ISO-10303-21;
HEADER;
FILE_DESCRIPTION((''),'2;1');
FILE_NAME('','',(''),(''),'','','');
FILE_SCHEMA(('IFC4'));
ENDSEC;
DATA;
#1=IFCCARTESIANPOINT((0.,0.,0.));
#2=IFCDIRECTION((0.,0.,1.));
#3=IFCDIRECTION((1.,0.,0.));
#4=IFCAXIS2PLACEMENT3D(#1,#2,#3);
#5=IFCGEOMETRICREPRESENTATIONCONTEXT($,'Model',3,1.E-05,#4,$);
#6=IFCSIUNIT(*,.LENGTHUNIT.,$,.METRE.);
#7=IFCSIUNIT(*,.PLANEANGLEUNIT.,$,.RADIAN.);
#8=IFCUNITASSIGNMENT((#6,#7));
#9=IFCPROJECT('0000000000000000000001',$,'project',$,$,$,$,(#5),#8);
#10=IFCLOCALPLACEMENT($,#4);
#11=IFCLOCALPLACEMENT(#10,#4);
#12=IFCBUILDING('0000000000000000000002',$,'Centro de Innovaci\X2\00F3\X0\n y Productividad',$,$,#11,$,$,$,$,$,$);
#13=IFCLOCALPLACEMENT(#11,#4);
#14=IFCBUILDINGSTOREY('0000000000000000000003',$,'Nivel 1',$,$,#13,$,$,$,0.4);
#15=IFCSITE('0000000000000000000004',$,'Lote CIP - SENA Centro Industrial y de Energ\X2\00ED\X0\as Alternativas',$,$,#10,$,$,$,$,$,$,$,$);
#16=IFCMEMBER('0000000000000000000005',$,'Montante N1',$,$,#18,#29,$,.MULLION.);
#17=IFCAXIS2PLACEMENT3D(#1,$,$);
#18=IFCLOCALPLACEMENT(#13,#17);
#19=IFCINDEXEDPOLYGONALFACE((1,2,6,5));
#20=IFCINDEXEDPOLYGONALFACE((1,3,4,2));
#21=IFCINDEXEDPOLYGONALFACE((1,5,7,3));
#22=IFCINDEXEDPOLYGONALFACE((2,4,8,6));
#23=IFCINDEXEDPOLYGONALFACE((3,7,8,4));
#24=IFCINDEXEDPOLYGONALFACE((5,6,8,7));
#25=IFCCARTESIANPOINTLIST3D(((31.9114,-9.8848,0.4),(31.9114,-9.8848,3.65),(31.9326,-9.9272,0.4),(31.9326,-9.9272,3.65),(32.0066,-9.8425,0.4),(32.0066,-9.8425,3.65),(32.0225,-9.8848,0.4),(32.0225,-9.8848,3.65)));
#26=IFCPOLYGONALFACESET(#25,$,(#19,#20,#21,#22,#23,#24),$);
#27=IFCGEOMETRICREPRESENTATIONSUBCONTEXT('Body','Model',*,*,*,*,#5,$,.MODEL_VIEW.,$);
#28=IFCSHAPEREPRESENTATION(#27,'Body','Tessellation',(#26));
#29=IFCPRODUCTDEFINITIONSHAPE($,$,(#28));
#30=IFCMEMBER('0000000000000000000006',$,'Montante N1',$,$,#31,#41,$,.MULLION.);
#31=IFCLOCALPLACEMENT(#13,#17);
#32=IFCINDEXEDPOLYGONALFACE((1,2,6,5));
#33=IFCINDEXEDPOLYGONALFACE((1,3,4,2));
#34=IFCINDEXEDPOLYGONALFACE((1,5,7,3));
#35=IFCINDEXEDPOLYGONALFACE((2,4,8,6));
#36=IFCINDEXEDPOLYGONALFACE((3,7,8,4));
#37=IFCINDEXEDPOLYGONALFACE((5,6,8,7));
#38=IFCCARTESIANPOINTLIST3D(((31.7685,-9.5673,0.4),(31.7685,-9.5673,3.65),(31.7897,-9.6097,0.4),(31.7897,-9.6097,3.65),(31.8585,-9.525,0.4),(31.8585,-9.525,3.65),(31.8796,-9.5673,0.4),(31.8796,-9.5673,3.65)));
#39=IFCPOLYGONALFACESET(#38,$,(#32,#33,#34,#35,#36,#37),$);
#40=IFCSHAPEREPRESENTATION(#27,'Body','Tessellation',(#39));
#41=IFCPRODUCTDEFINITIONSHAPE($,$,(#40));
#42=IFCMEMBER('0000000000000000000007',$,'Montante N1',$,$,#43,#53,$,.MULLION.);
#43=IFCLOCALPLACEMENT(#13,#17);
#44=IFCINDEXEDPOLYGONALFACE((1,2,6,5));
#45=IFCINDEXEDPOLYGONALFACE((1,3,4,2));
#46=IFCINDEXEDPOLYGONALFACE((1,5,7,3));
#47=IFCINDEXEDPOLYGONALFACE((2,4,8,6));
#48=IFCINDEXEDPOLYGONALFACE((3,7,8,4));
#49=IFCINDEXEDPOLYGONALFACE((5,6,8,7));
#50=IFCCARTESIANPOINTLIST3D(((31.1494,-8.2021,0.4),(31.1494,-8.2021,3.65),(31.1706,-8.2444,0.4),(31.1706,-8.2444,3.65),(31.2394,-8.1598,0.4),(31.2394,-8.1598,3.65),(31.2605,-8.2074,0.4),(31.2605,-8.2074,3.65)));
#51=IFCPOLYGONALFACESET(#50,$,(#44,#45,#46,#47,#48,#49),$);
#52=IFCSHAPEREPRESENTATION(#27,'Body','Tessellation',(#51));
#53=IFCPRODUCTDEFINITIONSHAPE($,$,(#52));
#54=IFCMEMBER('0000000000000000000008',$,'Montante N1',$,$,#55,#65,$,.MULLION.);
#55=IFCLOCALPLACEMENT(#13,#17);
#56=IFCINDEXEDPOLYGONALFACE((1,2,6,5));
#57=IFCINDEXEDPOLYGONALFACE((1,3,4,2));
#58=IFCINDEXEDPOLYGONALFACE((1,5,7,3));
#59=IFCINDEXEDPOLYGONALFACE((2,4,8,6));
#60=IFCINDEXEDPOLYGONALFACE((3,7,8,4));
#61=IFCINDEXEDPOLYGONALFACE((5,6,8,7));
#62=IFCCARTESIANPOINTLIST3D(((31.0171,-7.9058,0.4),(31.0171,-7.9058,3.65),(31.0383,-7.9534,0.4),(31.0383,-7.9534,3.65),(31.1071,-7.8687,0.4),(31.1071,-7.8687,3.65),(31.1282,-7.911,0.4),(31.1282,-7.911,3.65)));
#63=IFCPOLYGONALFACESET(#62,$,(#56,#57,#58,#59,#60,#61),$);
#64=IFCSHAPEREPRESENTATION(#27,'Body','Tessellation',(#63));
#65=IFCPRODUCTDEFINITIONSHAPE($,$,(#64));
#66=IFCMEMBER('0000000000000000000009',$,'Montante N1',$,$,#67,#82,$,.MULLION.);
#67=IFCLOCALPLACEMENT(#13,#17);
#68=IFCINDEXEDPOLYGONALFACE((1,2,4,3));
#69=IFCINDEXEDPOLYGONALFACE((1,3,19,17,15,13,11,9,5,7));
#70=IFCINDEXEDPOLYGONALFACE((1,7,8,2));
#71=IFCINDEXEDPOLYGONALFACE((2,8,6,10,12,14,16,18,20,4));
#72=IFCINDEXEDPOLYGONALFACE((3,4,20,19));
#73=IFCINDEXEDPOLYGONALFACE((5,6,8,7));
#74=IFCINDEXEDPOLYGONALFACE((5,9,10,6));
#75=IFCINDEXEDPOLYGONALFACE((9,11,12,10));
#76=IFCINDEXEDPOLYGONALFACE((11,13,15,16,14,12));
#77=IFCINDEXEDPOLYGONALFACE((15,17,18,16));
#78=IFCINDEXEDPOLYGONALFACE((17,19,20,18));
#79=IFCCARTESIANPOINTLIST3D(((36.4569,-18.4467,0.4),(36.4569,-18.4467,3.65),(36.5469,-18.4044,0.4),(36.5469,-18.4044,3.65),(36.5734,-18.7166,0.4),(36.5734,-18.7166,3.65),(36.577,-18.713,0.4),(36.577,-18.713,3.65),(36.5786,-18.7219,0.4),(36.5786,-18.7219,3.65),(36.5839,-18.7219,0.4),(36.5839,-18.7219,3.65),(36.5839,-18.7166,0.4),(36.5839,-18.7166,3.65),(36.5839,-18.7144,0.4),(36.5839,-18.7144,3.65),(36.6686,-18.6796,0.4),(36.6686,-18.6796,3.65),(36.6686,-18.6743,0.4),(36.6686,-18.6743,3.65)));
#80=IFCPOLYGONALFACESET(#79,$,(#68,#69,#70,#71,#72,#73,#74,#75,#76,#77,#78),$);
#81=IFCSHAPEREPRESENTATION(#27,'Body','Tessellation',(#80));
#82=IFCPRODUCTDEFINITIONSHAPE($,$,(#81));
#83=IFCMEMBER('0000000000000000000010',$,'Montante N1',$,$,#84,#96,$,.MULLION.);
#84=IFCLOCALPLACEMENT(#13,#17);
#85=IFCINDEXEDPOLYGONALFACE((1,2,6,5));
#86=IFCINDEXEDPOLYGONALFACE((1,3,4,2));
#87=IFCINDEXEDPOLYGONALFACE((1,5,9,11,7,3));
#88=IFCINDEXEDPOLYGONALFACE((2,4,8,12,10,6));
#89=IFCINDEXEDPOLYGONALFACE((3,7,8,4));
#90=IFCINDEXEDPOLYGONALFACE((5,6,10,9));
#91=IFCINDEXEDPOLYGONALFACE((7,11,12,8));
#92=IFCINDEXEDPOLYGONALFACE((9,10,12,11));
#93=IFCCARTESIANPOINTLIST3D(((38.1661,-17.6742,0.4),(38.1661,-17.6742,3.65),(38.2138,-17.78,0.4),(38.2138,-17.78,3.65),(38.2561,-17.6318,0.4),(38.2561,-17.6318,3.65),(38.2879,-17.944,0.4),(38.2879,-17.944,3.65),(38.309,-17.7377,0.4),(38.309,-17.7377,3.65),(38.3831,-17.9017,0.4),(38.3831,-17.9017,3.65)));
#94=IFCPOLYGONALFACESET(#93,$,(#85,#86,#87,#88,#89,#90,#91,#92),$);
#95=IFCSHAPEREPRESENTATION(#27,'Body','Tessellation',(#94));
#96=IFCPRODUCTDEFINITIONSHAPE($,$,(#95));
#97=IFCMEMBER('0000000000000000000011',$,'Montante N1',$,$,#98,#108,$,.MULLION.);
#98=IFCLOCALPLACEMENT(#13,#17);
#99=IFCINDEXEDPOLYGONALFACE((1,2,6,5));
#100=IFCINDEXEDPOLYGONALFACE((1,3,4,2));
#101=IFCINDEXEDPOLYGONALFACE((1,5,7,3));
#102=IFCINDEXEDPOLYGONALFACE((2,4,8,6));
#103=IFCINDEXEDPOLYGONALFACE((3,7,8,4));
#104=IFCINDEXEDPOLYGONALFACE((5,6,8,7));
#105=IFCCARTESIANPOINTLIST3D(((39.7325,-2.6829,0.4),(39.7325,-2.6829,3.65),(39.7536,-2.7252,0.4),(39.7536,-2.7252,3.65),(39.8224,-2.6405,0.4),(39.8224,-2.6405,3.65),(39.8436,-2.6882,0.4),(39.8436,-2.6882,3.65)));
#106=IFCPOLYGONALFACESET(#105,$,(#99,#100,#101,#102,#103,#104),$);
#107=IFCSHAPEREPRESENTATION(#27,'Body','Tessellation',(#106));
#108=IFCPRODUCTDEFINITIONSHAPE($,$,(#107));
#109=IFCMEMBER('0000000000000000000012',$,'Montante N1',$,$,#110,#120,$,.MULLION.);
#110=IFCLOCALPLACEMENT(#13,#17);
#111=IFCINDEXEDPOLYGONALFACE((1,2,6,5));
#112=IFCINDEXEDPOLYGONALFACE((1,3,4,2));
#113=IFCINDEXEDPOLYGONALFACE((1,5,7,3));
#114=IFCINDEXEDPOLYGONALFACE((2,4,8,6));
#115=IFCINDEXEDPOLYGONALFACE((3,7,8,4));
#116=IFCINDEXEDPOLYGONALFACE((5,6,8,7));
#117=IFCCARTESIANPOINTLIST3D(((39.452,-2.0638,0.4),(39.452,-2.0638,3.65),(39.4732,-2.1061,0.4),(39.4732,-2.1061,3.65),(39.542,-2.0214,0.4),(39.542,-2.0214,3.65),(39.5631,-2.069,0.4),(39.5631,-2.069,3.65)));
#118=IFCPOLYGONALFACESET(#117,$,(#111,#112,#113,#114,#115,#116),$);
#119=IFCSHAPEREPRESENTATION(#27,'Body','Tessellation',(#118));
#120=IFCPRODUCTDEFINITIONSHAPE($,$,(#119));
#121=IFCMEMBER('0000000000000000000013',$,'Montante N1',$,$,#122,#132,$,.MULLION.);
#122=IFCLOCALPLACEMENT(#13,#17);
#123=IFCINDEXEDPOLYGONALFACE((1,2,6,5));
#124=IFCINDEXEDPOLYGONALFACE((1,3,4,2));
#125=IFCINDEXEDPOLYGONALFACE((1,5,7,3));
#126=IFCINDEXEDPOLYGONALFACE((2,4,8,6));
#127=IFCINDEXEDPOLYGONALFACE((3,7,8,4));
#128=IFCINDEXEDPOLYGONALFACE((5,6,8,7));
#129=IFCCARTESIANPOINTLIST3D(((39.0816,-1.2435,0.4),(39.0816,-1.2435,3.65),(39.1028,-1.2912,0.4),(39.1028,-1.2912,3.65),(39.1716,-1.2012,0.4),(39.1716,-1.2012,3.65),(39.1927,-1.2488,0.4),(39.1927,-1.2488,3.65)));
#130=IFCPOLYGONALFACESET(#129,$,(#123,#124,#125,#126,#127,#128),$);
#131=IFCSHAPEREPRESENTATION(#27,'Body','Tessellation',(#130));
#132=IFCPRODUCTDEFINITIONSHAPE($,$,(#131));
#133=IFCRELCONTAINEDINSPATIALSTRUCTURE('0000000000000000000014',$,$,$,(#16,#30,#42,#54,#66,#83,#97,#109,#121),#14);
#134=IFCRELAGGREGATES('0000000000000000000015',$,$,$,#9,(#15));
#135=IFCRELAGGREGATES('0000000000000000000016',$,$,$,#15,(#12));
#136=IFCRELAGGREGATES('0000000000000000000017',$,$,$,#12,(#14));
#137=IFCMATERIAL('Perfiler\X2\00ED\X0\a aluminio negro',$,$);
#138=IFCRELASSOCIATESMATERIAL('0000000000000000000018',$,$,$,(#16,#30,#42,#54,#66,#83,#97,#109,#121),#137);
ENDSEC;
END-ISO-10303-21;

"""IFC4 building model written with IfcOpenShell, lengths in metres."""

from ifc_helpers import new_model, si_unit, frame, origin_with_axes, place, context, subcontext, project, spatial, polyline, outline, extrude, material, element, save


model = new_model("IFC4")

# Units and contexts
model_context = context("Model", 3, precision=1e-05, world=origin_with_axes())
body_context = subcontext(model_context, "Body", "Model", "MODEL_VIEW")
ifc_project = project(units=[si_unit("LENGTHUNIT", "METRE"), si_unit("PLANEANGLEUNIT", "RADIAN")], contexts=[model_context])

# Site, building, storey
site_placement = place(None, origin_with_axes())
site = spatial("IfcSite", under=ifc_project, at=site_placement, Name="Lote CIP - SENA Centro Industrial y de Energías Alternativas")
building_placement = place(site_placement, origin_with_axes())
building = spatial("IfcBuilding", under=site, at=building_placement, Name="Centro de Innovación y Productividad")
storey_placement = place(building_placement, origin_with_axes())
storey = spatial("IfcBuildingStorey", under=building, at=storey_placement, Name="Nivel 1", Elevation=0.4)

# Members
ifc_material = material(Name="Perfilería aluminio negro")
member_1_placement = place(storey_placement, origin_with_axes())
element("IfcMember", 1, at=member_1_placement, inside=storey, material=ifc_material, Name="Montante N1", PredefinedType="MULLION", context=body_context, shape_type="SweptSolid", body=[
    extrude(outline(polyline([(32.0066, -9.8425), (32.0225, -9.8848), (31.9326, -9.9272), (31.9114, -9.8848), (32.0066, -9.8425)])), frame((0.0, 0.0, 0.4)), (0.0, 0.0, 1.0), 3.25),
])
member_2_placement = place(storey_placement, origin_with_axes())
element("IfcMember", 2, at=member_2_placement, inside=storey, material=ifc_material, Name="Montante N1", PredefinedType="MULLION", context=body_context, shape_type="SweptSolid", body=[
    extrude(outline(polyline([(31.8585, -9.525), (31.8796, -9.5673), (31.7897, -9.6097), (31.7685, -9.5673), (31.8585, -9.525)])), frame((0.0, 0.0, 0.4)), (0.0, 0.0, 1.0), 3.25),
])
member_3_placement = place(storey_placement, origin_with_axes())
element("IfcMember", 3, at=member_3_placement, inside=storey, material=ifc_material, Name="Montante N1", PredefinedType="MULLION", context=body_context, shape_type="SweptSolid", body=[
    extrude(outline(polyline([(31.1494, -8.2021), (31.2394, -8.1598), (31.2605, -8.2074), (31.1706, -8.2444), (31.1494, -8.2021)])), frame((0.0, 0.0, 0.4)), (0.0, 0.0, 1.0), 3.25),
])
member_4_placement = place(storey_placement, origin_with_axes())
element("IfcMember", 4, at=member_4_placement, inside=storey, material=ifc_material, Name="Montante N1", PredefinedType="MULLION", context=body_context, shape_type="SweptSolid", body=[
    extrude(outline(polyline([(31.0171, -7.9058), (31.1071, -7.8687), (31.1282, -7.911), (31.0383, -7.9534), (31.0171, -7.9058)])), frame((0.0, 0.0, 0.4)), (0.0, 0.0, 1.0), 3.25),
])
member_5_placement = place(storey_placement, origin_with_axes())
element("IfcMember", 5, at=member_5_placement, inside=storey, material=ifc_material, Name="Montante N1", PredefinedType="MULLION", context=body_context, shape_type="SweptSolid", body=[
    extrude(outline(polyline([(36.5839, -18.7166), (36.5839, -18.7219), (36.5786, -18.7219), (36.5734, -18.7166), (36.577, -18.713), (36.4569, -18.4467), (36.5469, -18.4044), (36.6686, -18.6743), (36.6686, -18.6796), (36.5839, -18.7144), (36.5839, -18.7166)])), frame((0.0, 0.0, 0.4)), (0.0, 0.0, 1.0), 3.25),
])
member_6_placement = place(storey_placement, origin_with_axes())
element("IfcMember", 6, at=member_6_placement, inside=storey, material=ifc_material, Name="Montante N1", PredefinedType="MULLION", context=body_context, shape_type="SweptSolid", body=[
    extrude(outline(polyline([(38.2138, -17.78), (38.1661, -17.6742), (38.2561, -17.6318), (38.309, -17.7377), (38.3831, -17.9017), (38.2879, -17.944), (38.2138, -17.78)])), frame((0.0, 0.0, 0.4)), (0.0, 0.0, 1.0), 3.25),
])
member_7_placement = place(storey_placement, origin_with_axes())
element("IfcMember", 7, at=member_7_placement, inside=storey, material=ifc_material, Name="Montante N1", PredefinedType="MULLION", context=body_context, shape_type="SweptSolid", body=[
    extrude(outline(polyline([(39.8224, -2.6405), (39.8436, -2.6882), (39.7536, -2.7252), (39.7325, -2.6829), (39.8224, -2.6405)])), frame((0.0, 0.0, 0.4)), (0.0, 0.0, 1.0), 3.25),
])
member_8_placement = place(storey_placement, origin_with_axes())
element("IfcMember", 8, at=member_8_placement, inside=storey, material=ifc_material, Name="Montante N1", PredefinedType="MULLION", context=body_context, shape_type="SweptSolid", body=[
    extrude(outline(polyline([(39.542, -2.0214), (39.5631, -2.069), (39.4732, -2.1061), (39.452, -2.0638), (39.542, -2.0214)])), frame((0.0, 0.0, 0.4)), (0.0, 0.0, 1.0), 3.25),
])
member_9_placement = place(storey_placement, origin_with_axes())
element("IfcMember", 9, at=member_9_placement, inside=storey, material=ifc_material, Name="Montante N1", PredefinedType="MULLION", context=body_context, shape_type="SweptSolid", body=[
    extrude(outline(polyline([(39.1716, -1.2012), (39.1927, -1.2488), (39.1028, -1.2912), (39.0816, -1.2435), (39.1716, -1.2012)])), frame((0.0, 0.0, 0.4)), (0.0, 0.0, 1.0), 3.25),
])

save(model, "model.ifc")
